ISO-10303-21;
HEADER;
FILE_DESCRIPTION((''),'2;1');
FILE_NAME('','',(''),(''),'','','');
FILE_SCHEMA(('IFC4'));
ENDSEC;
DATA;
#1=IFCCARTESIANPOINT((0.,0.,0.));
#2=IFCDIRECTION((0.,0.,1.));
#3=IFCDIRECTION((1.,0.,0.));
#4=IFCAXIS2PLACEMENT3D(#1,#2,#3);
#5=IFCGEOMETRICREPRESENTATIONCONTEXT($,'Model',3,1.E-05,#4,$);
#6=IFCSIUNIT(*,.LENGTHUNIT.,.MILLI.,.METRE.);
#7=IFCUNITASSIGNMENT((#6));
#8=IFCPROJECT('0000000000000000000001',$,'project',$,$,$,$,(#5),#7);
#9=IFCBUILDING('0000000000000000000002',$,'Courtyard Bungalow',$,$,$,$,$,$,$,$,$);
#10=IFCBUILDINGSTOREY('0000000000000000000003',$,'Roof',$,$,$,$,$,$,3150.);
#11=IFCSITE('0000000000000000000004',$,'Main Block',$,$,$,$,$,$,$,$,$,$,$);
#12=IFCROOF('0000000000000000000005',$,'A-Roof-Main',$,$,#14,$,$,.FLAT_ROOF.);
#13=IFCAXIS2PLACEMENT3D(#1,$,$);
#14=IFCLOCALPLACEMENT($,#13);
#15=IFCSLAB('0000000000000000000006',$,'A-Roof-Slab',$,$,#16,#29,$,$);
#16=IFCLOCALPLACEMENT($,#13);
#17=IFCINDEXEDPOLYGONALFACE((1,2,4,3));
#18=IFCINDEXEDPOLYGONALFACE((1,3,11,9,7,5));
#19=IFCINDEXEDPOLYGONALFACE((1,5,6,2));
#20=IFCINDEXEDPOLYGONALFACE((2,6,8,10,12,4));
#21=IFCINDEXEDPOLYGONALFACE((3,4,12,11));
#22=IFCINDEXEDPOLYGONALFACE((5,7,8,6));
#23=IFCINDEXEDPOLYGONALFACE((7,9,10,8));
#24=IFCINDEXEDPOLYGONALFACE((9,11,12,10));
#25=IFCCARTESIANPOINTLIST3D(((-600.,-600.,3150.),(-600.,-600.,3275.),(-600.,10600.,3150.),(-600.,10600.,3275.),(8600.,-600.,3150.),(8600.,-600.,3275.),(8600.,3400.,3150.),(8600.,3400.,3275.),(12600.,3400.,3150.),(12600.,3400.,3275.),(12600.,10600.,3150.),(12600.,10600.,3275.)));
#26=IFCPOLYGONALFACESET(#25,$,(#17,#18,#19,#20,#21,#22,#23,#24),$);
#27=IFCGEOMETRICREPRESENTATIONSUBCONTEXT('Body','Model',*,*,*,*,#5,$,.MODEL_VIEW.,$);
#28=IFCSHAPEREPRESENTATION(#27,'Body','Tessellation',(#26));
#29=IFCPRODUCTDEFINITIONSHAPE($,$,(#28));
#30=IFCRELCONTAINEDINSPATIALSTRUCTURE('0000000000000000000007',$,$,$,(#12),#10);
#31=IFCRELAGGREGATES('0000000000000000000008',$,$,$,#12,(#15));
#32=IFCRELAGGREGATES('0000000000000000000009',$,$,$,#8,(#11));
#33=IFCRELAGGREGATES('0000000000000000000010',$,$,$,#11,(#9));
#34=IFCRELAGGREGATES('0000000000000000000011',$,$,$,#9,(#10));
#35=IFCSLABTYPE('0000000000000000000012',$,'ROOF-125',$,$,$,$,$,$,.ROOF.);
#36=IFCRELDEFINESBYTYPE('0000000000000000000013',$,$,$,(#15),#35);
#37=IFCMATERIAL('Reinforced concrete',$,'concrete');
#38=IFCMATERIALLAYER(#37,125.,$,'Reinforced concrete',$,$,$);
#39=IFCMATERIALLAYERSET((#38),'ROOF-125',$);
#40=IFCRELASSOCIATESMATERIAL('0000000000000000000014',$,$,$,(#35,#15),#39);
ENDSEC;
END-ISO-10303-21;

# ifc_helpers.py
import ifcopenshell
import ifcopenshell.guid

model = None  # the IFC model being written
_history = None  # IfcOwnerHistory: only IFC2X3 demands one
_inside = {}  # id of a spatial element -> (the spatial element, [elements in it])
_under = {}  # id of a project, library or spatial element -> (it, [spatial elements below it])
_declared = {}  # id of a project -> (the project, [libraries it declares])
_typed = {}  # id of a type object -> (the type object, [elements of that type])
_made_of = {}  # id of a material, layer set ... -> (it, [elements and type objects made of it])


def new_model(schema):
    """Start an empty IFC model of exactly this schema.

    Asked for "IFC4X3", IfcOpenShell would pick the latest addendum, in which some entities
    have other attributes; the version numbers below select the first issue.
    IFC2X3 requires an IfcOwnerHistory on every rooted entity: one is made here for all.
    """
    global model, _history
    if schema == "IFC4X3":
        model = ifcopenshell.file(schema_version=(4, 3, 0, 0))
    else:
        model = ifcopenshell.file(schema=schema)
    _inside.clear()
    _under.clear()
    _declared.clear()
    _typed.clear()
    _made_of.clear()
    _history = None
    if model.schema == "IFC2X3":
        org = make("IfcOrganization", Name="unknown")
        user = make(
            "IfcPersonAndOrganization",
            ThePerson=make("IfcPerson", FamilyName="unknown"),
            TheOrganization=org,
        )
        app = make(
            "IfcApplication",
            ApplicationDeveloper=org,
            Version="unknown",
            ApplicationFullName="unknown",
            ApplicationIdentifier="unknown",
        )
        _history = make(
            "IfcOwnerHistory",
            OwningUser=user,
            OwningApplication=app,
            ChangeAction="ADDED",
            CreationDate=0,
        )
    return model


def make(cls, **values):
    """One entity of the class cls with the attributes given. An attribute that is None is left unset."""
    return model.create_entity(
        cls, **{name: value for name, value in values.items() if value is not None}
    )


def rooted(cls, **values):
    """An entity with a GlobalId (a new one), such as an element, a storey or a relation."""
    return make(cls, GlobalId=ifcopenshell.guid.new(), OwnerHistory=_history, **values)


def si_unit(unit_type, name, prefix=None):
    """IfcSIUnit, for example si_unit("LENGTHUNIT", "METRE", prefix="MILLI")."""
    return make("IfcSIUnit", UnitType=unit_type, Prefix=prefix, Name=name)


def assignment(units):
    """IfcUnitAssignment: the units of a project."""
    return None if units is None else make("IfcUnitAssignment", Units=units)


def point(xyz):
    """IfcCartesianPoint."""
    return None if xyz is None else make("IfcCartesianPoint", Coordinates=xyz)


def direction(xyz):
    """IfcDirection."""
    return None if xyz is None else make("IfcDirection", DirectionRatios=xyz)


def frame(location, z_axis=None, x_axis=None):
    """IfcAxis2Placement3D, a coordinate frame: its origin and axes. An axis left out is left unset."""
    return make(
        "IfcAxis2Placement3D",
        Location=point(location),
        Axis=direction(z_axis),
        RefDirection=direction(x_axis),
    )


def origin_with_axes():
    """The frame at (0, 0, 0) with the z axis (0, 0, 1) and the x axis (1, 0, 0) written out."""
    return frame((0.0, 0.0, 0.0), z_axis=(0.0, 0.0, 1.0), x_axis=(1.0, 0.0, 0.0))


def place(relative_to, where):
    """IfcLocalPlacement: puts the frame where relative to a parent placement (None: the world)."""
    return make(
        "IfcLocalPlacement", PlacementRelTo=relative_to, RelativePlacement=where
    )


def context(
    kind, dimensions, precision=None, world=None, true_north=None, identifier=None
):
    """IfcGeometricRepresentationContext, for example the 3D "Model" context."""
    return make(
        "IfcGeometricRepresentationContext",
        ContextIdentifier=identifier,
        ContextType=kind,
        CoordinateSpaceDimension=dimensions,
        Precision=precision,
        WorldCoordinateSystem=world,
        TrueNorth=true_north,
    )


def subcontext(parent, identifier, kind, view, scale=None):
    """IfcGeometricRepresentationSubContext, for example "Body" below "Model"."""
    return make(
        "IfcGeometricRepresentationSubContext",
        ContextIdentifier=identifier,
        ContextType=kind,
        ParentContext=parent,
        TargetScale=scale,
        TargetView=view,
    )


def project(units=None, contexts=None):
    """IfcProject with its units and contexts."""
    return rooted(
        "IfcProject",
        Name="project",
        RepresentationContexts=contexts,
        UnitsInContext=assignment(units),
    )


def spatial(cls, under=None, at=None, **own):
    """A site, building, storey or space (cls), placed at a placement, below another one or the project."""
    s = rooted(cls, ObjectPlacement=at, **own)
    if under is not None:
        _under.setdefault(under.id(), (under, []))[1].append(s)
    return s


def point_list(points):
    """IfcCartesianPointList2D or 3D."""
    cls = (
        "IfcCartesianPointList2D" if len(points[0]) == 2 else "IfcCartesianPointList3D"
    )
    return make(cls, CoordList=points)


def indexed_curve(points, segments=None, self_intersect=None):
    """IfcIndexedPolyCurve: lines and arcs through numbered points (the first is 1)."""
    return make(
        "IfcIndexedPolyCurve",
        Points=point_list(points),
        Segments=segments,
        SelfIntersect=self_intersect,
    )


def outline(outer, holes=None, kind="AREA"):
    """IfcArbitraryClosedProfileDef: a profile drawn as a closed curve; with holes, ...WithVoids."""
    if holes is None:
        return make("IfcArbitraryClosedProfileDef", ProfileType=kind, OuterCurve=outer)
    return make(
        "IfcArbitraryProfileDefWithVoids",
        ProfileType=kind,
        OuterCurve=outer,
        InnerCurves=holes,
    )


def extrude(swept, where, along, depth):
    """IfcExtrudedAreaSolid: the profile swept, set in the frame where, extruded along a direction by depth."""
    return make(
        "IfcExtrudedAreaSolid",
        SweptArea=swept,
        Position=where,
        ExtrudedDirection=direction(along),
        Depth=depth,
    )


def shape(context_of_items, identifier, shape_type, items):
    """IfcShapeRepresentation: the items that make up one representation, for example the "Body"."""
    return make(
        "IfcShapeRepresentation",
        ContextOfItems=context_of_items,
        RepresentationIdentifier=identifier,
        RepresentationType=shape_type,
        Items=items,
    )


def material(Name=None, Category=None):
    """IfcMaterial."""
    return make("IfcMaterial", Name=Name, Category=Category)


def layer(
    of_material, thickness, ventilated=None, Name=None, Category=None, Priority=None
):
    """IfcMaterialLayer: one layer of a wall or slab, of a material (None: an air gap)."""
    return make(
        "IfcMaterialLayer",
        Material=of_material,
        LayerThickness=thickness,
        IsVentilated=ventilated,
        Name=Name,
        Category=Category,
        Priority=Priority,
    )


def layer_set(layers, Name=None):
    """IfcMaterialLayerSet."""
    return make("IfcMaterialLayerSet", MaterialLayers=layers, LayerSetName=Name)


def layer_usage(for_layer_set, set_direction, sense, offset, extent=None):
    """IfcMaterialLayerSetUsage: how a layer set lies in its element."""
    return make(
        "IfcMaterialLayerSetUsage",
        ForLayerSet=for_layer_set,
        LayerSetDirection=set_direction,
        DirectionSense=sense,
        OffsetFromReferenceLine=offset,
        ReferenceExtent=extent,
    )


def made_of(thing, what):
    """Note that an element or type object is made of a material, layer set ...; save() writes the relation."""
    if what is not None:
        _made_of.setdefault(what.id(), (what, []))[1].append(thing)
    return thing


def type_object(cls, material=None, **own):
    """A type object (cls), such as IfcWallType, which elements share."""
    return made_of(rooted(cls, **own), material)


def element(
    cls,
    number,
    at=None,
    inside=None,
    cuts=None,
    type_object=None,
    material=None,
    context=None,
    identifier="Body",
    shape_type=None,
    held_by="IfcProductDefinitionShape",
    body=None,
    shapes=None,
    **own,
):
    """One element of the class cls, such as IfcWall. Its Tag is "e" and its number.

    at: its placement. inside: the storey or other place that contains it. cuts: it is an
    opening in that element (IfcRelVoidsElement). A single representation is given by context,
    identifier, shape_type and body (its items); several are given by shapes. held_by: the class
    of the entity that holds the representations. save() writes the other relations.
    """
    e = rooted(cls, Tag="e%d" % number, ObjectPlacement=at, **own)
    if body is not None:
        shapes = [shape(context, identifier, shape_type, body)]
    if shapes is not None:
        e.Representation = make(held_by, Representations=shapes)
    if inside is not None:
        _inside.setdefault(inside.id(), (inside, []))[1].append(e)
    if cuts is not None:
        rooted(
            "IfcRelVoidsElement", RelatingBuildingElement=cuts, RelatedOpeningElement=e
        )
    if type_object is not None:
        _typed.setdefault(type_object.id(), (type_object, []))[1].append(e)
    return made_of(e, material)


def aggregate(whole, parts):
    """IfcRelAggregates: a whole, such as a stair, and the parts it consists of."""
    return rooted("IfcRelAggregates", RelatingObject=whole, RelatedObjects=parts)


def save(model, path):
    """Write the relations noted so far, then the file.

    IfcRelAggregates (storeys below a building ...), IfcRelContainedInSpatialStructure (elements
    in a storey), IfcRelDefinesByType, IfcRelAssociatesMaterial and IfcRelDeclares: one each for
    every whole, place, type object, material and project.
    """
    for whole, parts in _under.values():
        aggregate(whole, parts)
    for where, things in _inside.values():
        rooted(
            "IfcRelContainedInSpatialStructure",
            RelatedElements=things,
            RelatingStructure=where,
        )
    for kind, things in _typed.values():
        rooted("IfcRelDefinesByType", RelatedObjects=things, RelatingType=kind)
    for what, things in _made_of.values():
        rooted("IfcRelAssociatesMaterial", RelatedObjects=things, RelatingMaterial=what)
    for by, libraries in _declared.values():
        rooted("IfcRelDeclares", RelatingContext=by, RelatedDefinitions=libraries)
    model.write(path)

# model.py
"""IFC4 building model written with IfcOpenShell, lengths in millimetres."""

from ifc_helpers import new_model, si_unit, frame, origin_with_axes, place, context, subcontext, project, spatial, indexed_curve, outline, extrude, material, layer, layer_set, layer_usage, type_object, element, aggregate, save


model = new_model("IFC4")

# Units and contexts
model_context = context("Model", 3, precision=1e-05, world=origin_with_axes())
body_context = subcontext(model_context, "Body", "Model", "MODEL_VIEW")
ifc_project = project(units=[si_unit("LENGTHUNIT", "METRE", prefix="MILLI")], contexts=[model_context])

# Site, building, storey
site = spatial("IfcSite", under=ifc_project, Name="Main Block")
building = spatial("IfcBuilding", under=site, Name="Courtyard Bungalow")
storey = spatial("IfcBuildingStorey", under=building, Name="Roof", Elevation=3150.0)

# Roof, slab
roof = element("IfcRoof", 1, inside=storey, Name="A-Roof-Main", PredefinedType="FLAT_ROOF")
ifc_material = material(Name="Reinforced concrete", Category="concrete")
ifc_layer = layer(ifc_material, 125.0, Name="Reinforced concrete")
ifc_layer_set = layer_set([ifc_layer], Name="ROOF-125")
ifc_layer_usage = layer_usage(ifc_layer_set, "AXIS3", "POSITIVE", 0.0)
slab_type = type_object("IfcSlabType", Name="ROOF-125", PredefinedType="ROOF", material=ifc_layer_set)
slab_placement = place(None, frame((0.0, 0.0, 3150.0), z_axis=(0.0, 0.0, 1.0), x_axis=(1.0, 0.0, 0.0)))
slab = element("IfcSlab", 2, at=slab_placement, type_object=slab_type, material=ifc_layer_usage, Name="A-Roof-Slab", context=body_context, shape_type="SweptSolid", body=[
    extrude(outline(indexed_curve([(-600.0, -600.0), (8600.0, -600.0), (8600.0, 3400.0), (12600.0, 3400.0), (12600.0, 10600.0), (-600.0, 10600.0)])), None, (0.0, 0.0, 1.0), 125.0),
])
aggregate(roof, [slab])

save(model, "model.ifc")
